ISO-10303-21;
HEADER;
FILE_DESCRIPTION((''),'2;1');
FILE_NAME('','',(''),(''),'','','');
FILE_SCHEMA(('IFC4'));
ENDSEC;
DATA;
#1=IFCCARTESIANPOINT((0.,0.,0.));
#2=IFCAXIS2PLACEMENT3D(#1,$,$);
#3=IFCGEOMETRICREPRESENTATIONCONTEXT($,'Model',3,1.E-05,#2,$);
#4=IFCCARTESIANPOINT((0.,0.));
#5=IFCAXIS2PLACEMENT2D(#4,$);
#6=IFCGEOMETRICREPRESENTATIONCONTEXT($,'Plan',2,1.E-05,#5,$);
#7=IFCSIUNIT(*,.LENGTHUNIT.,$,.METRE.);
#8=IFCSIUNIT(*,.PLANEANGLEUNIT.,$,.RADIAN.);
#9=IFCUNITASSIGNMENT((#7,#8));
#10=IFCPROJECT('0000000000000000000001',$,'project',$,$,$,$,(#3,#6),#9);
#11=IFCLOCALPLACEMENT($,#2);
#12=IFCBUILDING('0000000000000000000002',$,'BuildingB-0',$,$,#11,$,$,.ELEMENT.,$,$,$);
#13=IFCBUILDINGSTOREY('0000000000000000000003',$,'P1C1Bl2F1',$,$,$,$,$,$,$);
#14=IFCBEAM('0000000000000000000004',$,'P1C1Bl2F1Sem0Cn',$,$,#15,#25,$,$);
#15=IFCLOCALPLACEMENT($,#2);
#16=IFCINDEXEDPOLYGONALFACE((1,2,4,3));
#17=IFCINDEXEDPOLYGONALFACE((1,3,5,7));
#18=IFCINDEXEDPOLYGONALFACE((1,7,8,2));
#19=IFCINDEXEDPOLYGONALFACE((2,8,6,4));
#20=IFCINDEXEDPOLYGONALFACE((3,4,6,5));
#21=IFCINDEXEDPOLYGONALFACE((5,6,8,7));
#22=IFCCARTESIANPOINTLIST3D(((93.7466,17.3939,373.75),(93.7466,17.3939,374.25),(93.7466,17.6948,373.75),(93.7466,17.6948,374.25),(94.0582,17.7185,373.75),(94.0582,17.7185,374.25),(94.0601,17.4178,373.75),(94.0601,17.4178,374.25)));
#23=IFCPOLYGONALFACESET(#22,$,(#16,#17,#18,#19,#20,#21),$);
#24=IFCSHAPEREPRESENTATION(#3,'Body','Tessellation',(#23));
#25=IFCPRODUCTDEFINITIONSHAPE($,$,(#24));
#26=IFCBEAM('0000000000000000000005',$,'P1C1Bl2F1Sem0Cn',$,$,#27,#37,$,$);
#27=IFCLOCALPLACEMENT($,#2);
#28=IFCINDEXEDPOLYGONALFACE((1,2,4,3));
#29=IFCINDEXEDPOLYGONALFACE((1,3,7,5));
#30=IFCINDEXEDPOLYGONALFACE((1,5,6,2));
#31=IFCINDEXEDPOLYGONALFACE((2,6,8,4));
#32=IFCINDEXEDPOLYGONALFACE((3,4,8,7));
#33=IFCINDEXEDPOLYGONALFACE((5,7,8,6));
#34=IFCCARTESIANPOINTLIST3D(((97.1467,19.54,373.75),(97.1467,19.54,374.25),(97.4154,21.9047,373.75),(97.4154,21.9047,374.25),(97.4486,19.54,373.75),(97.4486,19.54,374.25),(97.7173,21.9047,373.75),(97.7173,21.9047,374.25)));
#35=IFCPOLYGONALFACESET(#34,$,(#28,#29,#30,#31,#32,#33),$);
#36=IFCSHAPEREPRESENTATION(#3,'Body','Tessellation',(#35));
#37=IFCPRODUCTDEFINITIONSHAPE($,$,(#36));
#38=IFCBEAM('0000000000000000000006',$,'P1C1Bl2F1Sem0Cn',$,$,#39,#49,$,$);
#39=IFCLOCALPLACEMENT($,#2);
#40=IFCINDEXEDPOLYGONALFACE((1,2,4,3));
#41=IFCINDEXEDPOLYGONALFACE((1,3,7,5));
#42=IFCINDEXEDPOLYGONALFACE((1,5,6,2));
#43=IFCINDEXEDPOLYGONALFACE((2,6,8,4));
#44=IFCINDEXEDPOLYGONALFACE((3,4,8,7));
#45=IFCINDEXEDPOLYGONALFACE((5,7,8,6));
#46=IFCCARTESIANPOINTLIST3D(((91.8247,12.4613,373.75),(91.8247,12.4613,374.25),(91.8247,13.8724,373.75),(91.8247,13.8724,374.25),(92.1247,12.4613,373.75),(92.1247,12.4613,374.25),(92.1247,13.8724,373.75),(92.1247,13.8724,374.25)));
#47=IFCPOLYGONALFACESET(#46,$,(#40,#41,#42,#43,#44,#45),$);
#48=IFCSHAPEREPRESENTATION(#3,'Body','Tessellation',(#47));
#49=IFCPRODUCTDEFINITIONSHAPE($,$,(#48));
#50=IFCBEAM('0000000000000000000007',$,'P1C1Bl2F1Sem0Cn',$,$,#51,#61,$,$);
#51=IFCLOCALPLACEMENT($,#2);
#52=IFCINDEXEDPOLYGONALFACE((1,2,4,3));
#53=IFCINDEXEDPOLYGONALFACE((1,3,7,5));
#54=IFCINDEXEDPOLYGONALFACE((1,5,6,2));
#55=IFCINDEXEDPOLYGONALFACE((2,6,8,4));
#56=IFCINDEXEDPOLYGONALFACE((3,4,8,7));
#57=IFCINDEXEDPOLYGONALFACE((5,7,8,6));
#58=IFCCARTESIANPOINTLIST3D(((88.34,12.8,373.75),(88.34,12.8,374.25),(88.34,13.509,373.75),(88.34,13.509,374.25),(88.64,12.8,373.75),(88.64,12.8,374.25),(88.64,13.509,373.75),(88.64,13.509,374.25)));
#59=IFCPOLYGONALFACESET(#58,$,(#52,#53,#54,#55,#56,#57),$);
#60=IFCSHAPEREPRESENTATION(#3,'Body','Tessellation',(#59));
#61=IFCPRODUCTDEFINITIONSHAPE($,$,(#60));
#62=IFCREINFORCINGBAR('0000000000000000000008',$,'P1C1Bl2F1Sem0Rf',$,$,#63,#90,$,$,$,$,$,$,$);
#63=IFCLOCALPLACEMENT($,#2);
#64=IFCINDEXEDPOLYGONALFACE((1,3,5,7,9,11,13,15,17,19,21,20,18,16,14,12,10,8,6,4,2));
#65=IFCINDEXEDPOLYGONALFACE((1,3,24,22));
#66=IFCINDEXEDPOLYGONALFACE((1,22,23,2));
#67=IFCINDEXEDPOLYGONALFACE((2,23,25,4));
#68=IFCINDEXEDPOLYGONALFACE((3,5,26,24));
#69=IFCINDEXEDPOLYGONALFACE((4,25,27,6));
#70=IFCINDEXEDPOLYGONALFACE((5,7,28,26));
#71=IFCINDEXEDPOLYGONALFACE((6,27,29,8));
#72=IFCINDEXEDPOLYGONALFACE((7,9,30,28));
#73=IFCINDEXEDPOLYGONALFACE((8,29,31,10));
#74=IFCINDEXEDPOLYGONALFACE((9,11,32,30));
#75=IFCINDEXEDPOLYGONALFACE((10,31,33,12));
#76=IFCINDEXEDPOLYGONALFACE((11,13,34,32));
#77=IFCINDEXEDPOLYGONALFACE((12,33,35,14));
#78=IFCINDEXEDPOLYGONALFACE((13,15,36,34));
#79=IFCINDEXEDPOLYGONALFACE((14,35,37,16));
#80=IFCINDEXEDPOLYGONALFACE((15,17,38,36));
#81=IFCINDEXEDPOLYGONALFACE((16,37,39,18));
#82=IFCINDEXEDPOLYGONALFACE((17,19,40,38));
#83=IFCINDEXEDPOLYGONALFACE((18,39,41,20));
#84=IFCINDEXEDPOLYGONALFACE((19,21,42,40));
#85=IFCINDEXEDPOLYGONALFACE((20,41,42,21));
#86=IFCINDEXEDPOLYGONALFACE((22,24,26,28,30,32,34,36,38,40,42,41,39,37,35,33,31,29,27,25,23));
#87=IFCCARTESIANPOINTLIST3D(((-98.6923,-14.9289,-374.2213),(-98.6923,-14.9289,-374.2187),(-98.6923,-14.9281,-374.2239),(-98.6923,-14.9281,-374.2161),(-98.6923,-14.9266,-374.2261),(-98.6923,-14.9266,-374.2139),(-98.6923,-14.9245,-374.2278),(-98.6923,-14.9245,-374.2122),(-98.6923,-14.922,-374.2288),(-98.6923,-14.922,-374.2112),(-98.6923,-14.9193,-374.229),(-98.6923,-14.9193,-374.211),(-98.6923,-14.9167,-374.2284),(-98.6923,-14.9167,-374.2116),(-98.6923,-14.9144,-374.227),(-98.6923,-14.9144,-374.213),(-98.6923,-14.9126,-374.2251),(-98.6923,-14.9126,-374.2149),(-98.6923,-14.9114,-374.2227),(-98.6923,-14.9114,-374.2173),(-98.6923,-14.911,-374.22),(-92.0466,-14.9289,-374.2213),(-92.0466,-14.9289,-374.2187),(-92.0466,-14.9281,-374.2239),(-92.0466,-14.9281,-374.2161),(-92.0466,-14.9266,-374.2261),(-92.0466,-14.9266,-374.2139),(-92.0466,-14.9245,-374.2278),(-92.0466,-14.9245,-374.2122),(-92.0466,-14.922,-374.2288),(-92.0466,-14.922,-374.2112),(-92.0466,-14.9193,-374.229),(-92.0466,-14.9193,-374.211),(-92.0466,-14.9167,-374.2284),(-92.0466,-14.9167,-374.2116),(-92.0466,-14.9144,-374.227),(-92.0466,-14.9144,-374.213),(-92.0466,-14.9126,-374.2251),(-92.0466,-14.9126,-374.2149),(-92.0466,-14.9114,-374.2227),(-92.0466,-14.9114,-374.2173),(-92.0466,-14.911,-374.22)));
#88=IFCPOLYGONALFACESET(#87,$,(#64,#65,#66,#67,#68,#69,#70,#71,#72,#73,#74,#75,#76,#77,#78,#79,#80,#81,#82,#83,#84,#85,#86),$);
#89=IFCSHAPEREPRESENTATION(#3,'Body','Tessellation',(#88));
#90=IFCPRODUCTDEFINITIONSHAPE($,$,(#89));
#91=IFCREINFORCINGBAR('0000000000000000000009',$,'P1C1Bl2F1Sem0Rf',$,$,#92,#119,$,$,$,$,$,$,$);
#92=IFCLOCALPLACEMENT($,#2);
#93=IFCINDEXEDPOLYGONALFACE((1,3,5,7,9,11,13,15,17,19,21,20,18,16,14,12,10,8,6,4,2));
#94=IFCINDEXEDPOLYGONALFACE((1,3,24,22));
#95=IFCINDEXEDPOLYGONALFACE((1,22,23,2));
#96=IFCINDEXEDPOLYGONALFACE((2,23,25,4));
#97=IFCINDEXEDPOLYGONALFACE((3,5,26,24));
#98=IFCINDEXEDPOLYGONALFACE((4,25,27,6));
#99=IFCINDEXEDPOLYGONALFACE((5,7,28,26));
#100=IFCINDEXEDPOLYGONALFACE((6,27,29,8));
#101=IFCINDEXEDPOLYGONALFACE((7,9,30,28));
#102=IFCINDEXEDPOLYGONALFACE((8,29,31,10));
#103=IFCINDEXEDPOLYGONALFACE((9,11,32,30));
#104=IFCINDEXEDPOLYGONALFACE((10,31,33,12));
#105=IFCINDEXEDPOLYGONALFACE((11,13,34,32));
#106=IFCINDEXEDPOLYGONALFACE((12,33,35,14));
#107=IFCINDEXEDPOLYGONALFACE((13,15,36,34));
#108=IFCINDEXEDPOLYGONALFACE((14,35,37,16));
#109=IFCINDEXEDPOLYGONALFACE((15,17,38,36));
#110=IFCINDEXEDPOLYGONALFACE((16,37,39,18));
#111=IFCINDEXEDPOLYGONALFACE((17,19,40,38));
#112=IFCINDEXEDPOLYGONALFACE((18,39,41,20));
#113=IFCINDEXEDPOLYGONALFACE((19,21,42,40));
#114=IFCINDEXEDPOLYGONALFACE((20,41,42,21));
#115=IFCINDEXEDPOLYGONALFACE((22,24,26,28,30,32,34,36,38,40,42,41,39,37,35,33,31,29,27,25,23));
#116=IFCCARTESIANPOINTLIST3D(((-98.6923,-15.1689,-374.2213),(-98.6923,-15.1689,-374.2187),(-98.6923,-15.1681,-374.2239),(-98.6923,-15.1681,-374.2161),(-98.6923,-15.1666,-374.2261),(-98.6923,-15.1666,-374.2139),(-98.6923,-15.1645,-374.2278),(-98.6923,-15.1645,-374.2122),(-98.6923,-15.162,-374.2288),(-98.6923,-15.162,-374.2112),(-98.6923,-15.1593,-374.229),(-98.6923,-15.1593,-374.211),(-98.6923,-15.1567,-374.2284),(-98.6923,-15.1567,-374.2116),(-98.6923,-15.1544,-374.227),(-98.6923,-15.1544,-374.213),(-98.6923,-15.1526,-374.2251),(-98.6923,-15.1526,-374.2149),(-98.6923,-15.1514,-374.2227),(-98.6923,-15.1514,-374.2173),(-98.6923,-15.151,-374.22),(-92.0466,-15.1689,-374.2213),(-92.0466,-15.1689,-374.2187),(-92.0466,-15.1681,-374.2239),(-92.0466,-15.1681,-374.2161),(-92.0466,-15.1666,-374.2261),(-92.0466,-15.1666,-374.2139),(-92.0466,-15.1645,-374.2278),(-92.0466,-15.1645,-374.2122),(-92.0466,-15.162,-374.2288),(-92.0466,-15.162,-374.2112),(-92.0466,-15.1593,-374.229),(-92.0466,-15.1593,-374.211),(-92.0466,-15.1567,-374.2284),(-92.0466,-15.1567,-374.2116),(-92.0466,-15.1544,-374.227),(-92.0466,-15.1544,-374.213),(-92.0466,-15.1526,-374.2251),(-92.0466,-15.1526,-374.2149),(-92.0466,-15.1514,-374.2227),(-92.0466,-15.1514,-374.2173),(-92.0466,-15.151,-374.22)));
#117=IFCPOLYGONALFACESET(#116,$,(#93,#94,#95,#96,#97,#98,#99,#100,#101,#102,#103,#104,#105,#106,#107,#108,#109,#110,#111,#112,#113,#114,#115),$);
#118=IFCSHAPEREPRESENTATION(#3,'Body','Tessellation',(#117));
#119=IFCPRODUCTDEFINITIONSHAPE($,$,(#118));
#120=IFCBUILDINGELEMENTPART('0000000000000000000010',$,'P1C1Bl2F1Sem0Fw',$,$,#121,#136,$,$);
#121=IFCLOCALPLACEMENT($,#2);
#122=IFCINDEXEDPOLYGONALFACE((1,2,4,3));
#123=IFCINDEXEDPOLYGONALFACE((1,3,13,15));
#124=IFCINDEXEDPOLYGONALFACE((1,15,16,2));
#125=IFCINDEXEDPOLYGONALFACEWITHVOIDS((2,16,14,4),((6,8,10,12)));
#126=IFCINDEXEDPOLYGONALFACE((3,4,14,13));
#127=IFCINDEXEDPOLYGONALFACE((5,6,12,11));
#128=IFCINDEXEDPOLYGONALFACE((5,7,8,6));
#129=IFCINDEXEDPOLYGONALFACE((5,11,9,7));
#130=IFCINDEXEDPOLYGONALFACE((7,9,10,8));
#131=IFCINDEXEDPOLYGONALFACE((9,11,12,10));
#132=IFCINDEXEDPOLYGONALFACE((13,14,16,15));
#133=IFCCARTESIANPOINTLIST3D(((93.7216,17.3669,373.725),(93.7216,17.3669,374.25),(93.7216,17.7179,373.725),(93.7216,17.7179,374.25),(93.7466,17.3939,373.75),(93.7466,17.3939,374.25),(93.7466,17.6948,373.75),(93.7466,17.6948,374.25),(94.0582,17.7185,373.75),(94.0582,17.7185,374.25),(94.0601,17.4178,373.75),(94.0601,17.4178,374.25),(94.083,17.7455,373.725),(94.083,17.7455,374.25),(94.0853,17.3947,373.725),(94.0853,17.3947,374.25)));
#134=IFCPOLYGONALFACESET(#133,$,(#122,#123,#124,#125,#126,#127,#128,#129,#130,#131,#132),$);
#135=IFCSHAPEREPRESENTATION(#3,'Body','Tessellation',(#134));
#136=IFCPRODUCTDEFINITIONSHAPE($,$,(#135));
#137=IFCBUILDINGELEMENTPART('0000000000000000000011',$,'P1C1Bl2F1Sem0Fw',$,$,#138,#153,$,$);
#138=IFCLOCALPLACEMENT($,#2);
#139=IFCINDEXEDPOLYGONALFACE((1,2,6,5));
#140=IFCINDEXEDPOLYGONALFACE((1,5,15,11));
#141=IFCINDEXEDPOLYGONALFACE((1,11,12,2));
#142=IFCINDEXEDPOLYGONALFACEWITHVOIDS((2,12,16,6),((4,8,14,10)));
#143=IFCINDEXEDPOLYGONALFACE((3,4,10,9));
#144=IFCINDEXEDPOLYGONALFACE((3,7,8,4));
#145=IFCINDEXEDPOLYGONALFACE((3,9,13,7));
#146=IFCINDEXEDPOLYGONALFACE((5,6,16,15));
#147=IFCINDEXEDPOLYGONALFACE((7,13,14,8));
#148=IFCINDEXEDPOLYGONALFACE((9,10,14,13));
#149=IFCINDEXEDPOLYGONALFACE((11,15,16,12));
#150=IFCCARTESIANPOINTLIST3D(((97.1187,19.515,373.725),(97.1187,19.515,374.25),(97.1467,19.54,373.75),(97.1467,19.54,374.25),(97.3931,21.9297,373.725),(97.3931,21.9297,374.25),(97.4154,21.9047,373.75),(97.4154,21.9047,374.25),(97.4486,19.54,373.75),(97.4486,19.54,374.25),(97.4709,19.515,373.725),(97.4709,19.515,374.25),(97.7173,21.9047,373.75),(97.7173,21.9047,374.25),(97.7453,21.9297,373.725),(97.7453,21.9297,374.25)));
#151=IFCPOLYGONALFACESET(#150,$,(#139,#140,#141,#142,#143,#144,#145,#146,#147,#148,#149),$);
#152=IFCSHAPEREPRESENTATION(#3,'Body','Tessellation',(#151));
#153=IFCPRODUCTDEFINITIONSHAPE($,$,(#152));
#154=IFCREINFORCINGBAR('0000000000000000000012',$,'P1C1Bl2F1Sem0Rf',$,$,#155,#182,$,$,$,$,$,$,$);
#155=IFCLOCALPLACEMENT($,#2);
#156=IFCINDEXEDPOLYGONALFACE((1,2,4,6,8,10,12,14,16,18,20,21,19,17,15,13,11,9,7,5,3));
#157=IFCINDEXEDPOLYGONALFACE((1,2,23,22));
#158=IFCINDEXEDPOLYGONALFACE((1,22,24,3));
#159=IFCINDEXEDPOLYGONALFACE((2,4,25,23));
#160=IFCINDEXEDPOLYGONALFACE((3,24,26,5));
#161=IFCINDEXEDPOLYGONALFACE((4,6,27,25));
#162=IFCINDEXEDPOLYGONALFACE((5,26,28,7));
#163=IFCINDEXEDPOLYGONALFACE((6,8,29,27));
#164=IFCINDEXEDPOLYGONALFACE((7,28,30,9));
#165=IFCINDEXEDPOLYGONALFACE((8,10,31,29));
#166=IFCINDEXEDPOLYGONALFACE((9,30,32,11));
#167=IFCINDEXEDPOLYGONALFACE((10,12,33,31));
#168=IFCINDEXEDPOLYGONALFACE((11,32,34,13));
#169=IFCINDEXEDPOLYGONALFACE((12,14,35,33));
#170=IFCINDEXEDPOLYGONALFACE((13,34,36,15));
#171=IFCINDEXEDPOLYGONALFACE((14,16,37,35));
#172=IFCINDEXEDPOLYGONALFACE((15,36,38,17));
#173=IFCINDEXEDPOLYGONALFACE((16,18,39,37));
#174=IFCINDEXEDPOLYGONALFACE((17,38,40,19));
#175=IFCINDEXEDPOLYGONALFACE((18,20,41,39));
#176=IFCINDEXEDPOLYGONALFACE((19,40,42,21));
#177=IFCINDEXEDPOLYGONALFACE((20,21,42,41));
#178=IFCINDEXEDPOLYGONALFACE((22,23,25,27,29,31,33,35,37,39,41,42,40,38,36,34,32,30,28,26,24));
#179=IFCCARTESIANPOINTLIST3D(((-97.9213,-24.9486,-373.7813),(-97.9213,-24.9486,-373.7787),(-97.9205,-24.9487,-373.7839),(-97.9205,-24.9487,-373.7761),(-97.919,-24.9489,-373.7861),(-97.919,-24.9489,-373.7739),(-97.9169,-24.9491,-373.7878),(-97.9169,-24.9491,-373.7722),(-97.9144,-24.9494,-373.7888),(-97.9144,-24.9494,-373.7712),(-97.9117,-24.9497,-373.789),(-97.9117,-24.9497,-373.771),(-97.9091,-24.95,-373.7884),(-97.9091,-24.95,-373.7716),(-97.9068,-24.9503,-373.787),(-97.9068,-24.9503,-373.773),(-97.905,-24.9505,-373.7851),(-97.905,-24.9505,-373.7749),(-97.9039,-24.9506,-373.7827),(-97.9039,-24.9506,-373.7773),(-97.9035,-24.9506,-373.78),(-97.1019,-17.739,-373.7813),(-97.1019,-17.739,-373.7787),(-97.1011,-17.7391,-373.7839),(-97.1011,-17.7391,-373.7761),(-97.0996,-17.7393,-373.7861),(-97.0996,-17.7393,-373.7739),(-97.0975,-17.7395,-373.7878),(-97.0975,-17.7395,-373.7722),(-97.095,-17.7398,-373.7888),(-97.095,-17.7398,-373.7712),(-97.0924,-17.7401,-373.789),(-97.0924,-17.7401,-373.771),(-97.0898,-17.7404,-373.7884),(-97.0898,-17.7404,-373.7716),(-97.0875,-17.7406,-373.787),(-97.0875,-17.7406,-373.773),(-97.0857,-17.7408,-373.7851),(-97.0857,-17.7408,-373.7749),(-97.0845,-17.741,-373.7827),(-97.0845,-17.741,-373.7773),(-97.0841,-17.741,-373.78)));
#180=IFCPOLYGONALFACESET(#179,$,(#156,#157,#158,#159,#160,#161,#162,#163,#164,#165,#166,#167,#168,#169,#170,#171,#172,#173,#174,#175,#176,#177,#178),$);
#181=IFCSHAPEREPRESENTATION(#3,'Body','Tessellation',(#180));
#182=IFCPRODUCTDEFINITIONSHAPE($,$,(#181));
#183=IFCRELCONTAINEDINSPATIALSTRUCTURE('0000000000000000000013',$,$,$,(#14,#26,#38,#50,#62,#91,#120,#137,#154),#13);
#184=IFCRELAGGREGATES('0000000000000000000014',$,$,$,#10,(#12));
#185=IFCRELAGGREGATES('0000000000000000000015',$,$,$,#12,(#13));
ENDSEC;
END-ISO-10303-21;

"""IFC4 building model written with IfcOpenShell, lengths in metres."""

from ifc_helpers import new_model, entity, si_unit, origin, origin_2d, place, context, project, spatial, polyline, outline, extrude, element, save


model = new_model("IFC4")

# Units and contexts
model_context = context("Model", 3, precision=1e-05, world=origin())
plan_context = context("Plan", 2, precision=1e-05, world=origin_2d())
ifc_project = project(units=[si_unit("LENGTHUNIT", "METRE"), si_unit("PLANEANGLEUNIT", "RADIAN")], contexts=[model_context, plan_context])

# Building, storey
building_placement = place(None, origin())
building = spatial("IfcBuilding", under=ifc_project, at=building_placement, Name="BuildingB-0", CompositionType="ELEMENT")
storey = spatial("IfcBuildingStorey", under=building, Name="P1C1Bl2F1")

# Beams
element("IfcBeam", 1, inside=storey, Name="P1C1Bl2F1Sem0Cn", context=model_context, shape_type="SweptSolid", body=[
    extrude(outline(polyline([(94.0601, 17.4178, 373.75), (93.7466, 17.3939, 373.75), (93.7466, 17.6948, 373.75), (94.0582, 17.7185, 373.75), (94.0601, 17.4178, 373.75)])), None, (0.0, 0.0, 1.0), 0.5),
])
element("IfcBeam", 2, inside=storey, Name="P1C1Bl2F1Sem0Cn", context=model_context, shape_type="SweptSolid", body=[
    extrude(outline(polyline([(97.4486, 19.54, 373.75), (97.1467, 19.54, 373.75), (97.4154, 21.9047, 373.75), (97.7173, 21.9047, 373.75), (97.4486, 19.54, 373.75)])), None, (0.0, 0.0, 1.0), 0.5),
])
element("IfcBeam", 3, inside=storey, Name="P1C1Bl2F1Sem0Cn", context=model_context, shape_type="SweptSolid", body=[
    extrude(outline(polyline([(92.1247, 12.4613, 373.75), (91.8247, 12.4613, 373.75), (91.8247, 13.8724, 373.75), (92.1247, 13.8724, 373.75), (92.1247, 12.4613, 373.75)])), None, (0.0, 0.0, 1.0), 0.5),
])
element("IfcBeam", 4, inside=storey, Name="P1C1Bl2F1Sem0Cn", context=model_context, shape_type="SweptSolid", body=[
    extrude(outline(polyline([(88.64, 12.8, 373.75), (88.34, 12.8, 373.75), (88.34, 13.509, 373.75), (88.64, 13.509, 373.75), (88.64, 12.8, 373.75)])), None, (0.0, 0.0, 1.0), 0.5),
])

# Reinforcing bars
element("IfcReinforcingBar", 5, inside=storey, Name="P1C1Bl2F1Sem0Rf", context=model_context, shape_type="SweptSolid", body=[
    entity("IfcSurfaceCurveSweptAreaSolid", entity("IfcCircleProfileDef", "AREA", None, None, 0.009), None, entity("IfcPolyline", [entity("IfcCartesianPoint", [92.0466, 14.92, 374.22]), entity("IfcCartesianPoint", [98.6923, 14.92, 374.22])]), None, None, entity("IfcPlane", entity("IfcAxis2Placement3D", entity("IfcCartesianPoint", [92.0466, 14.92, 374.22]), entity("IfcDirection", [0.0, 0.0, 1.0]), entity("IfcDirection", [1.0, 0.0, 0.0])))),
])
element("IfcReinforcingBar", 6, inside=storey, Name="P1C1Bl2F1Sem0Rf", context=model_context, shape_type="SweptSolid", body=[
    entity("IfcSurfaceCurveSweptAreaSolid", entity("IfcCircleProfileDef", "AREA", None, None, 0.009), None, entity("IfcPolyline", [entity("IfcCartesianPoint", [92.0466, 15.16, 374.22]), entity("IfcCartesianPoint", [98.6923, 15.16, 374.22])]), None, None, entity("IfcPlane", entity("IfcAxis2Placement3D", entity("IfcCartesianPoint", [92.0466, 15.16, 374.22]), entity("IfcDirection", [0.0, 0.0, 1.0]), entity("IfcDirection", [1.0, 0.0, 0.0])))),
])

# Building element parts, openings
building_element_part_1 = element("IfcBuildingElementPart", 7, inside=storey, Name="P1C1Bl2F1Sem0Fw", context=model_context, shape_type="SweptSolid", body=[
    extrude(outline(polyline([(94.0853, 17.3947, 373.725), (93.7216, 17.3669, 373.725), (93.7216, 17.7179, 373.725), (94.083, 17.7455, 373.725), (94.0853, 17.3947, 373.725)])), None, (0.0, 0.0, 1.0), 0.525),
])
element("IfcOpeningElement", 8, inside=storey, cuts=building_element_part_1, context=model_context, shape_type="SweptSolid", body=[
    extrude(outline(polyline([(94.0601, 17.4178, 373.75), (93.7466, 17.3939, 373.75), (93.7466, 17.6948, 373.75), (94.0582, 17.7185, 373.75), (94.0601, 17.4178, 373.75)])), None, (0.0, 0.0, 1.0), 0.5),
])
building_element_part_2 = element("IfcBuildingElementPart", 9, inside=storey, Name="P1C1Bl2F1Sem0Fw", context=model_context, shape_type="SweptSolid", body=[
    extrude(outline(polyline([(97.4709, 19.515, 373.725), (97.1187, 19.515, 373.725), (97.3931, 21.9297, 373.725), (97.7453, 21.9297, 373.725), (97.4709, 19.515, 373.725)])), None, (0.0, 0.0, 1.0), 0.525),
])
element("IfcOpeningElement", 10, inside=storey, cuts=building_element_part_2, context=model_context, shape_type="SweptSolid", body=[
    extrude(outline(polyline([(97.4486, 19.54, 373.75), (97.1467, 19.54, 373.75), (97.4154, 21.9047, 373.75), (97.7173, 21.9047, 373.75), (97.4486, 19.54, 373.75)])), None, (0.0, 0.0, 1.0), 0.5),
])

# Reinforcing bar
element("IfcReinforcingBar", 11, inside=storey, Name="P1C1Bl2F1Sem0Rf", context=model_context, shape_type="SweptSolid", body=[
    entity("IfcSurfaceCurveSweptAreaSolid", entity("IfcCircleProfileDef", "AREA", None, None, 0.009), None, entity("IfcPolyline", [entity("IfcCartesianPoint", [97.0931, 17.74, 373.78]), entity("IfcCartesianPoint", [97.9124, 24.9496, 373.78])]), None, None, entity("IfcPlane", entity("IfcAxis2Placement3D", entity("IfcCartesianPoint", [97.0931, 17.74, 373.78]), entity("IfcDirection", [0.0, 0.0, 1.0]), entity("IfcDirection", [1.0, 0.0, 0.0])))),
])

save(model, "model.ifc")
